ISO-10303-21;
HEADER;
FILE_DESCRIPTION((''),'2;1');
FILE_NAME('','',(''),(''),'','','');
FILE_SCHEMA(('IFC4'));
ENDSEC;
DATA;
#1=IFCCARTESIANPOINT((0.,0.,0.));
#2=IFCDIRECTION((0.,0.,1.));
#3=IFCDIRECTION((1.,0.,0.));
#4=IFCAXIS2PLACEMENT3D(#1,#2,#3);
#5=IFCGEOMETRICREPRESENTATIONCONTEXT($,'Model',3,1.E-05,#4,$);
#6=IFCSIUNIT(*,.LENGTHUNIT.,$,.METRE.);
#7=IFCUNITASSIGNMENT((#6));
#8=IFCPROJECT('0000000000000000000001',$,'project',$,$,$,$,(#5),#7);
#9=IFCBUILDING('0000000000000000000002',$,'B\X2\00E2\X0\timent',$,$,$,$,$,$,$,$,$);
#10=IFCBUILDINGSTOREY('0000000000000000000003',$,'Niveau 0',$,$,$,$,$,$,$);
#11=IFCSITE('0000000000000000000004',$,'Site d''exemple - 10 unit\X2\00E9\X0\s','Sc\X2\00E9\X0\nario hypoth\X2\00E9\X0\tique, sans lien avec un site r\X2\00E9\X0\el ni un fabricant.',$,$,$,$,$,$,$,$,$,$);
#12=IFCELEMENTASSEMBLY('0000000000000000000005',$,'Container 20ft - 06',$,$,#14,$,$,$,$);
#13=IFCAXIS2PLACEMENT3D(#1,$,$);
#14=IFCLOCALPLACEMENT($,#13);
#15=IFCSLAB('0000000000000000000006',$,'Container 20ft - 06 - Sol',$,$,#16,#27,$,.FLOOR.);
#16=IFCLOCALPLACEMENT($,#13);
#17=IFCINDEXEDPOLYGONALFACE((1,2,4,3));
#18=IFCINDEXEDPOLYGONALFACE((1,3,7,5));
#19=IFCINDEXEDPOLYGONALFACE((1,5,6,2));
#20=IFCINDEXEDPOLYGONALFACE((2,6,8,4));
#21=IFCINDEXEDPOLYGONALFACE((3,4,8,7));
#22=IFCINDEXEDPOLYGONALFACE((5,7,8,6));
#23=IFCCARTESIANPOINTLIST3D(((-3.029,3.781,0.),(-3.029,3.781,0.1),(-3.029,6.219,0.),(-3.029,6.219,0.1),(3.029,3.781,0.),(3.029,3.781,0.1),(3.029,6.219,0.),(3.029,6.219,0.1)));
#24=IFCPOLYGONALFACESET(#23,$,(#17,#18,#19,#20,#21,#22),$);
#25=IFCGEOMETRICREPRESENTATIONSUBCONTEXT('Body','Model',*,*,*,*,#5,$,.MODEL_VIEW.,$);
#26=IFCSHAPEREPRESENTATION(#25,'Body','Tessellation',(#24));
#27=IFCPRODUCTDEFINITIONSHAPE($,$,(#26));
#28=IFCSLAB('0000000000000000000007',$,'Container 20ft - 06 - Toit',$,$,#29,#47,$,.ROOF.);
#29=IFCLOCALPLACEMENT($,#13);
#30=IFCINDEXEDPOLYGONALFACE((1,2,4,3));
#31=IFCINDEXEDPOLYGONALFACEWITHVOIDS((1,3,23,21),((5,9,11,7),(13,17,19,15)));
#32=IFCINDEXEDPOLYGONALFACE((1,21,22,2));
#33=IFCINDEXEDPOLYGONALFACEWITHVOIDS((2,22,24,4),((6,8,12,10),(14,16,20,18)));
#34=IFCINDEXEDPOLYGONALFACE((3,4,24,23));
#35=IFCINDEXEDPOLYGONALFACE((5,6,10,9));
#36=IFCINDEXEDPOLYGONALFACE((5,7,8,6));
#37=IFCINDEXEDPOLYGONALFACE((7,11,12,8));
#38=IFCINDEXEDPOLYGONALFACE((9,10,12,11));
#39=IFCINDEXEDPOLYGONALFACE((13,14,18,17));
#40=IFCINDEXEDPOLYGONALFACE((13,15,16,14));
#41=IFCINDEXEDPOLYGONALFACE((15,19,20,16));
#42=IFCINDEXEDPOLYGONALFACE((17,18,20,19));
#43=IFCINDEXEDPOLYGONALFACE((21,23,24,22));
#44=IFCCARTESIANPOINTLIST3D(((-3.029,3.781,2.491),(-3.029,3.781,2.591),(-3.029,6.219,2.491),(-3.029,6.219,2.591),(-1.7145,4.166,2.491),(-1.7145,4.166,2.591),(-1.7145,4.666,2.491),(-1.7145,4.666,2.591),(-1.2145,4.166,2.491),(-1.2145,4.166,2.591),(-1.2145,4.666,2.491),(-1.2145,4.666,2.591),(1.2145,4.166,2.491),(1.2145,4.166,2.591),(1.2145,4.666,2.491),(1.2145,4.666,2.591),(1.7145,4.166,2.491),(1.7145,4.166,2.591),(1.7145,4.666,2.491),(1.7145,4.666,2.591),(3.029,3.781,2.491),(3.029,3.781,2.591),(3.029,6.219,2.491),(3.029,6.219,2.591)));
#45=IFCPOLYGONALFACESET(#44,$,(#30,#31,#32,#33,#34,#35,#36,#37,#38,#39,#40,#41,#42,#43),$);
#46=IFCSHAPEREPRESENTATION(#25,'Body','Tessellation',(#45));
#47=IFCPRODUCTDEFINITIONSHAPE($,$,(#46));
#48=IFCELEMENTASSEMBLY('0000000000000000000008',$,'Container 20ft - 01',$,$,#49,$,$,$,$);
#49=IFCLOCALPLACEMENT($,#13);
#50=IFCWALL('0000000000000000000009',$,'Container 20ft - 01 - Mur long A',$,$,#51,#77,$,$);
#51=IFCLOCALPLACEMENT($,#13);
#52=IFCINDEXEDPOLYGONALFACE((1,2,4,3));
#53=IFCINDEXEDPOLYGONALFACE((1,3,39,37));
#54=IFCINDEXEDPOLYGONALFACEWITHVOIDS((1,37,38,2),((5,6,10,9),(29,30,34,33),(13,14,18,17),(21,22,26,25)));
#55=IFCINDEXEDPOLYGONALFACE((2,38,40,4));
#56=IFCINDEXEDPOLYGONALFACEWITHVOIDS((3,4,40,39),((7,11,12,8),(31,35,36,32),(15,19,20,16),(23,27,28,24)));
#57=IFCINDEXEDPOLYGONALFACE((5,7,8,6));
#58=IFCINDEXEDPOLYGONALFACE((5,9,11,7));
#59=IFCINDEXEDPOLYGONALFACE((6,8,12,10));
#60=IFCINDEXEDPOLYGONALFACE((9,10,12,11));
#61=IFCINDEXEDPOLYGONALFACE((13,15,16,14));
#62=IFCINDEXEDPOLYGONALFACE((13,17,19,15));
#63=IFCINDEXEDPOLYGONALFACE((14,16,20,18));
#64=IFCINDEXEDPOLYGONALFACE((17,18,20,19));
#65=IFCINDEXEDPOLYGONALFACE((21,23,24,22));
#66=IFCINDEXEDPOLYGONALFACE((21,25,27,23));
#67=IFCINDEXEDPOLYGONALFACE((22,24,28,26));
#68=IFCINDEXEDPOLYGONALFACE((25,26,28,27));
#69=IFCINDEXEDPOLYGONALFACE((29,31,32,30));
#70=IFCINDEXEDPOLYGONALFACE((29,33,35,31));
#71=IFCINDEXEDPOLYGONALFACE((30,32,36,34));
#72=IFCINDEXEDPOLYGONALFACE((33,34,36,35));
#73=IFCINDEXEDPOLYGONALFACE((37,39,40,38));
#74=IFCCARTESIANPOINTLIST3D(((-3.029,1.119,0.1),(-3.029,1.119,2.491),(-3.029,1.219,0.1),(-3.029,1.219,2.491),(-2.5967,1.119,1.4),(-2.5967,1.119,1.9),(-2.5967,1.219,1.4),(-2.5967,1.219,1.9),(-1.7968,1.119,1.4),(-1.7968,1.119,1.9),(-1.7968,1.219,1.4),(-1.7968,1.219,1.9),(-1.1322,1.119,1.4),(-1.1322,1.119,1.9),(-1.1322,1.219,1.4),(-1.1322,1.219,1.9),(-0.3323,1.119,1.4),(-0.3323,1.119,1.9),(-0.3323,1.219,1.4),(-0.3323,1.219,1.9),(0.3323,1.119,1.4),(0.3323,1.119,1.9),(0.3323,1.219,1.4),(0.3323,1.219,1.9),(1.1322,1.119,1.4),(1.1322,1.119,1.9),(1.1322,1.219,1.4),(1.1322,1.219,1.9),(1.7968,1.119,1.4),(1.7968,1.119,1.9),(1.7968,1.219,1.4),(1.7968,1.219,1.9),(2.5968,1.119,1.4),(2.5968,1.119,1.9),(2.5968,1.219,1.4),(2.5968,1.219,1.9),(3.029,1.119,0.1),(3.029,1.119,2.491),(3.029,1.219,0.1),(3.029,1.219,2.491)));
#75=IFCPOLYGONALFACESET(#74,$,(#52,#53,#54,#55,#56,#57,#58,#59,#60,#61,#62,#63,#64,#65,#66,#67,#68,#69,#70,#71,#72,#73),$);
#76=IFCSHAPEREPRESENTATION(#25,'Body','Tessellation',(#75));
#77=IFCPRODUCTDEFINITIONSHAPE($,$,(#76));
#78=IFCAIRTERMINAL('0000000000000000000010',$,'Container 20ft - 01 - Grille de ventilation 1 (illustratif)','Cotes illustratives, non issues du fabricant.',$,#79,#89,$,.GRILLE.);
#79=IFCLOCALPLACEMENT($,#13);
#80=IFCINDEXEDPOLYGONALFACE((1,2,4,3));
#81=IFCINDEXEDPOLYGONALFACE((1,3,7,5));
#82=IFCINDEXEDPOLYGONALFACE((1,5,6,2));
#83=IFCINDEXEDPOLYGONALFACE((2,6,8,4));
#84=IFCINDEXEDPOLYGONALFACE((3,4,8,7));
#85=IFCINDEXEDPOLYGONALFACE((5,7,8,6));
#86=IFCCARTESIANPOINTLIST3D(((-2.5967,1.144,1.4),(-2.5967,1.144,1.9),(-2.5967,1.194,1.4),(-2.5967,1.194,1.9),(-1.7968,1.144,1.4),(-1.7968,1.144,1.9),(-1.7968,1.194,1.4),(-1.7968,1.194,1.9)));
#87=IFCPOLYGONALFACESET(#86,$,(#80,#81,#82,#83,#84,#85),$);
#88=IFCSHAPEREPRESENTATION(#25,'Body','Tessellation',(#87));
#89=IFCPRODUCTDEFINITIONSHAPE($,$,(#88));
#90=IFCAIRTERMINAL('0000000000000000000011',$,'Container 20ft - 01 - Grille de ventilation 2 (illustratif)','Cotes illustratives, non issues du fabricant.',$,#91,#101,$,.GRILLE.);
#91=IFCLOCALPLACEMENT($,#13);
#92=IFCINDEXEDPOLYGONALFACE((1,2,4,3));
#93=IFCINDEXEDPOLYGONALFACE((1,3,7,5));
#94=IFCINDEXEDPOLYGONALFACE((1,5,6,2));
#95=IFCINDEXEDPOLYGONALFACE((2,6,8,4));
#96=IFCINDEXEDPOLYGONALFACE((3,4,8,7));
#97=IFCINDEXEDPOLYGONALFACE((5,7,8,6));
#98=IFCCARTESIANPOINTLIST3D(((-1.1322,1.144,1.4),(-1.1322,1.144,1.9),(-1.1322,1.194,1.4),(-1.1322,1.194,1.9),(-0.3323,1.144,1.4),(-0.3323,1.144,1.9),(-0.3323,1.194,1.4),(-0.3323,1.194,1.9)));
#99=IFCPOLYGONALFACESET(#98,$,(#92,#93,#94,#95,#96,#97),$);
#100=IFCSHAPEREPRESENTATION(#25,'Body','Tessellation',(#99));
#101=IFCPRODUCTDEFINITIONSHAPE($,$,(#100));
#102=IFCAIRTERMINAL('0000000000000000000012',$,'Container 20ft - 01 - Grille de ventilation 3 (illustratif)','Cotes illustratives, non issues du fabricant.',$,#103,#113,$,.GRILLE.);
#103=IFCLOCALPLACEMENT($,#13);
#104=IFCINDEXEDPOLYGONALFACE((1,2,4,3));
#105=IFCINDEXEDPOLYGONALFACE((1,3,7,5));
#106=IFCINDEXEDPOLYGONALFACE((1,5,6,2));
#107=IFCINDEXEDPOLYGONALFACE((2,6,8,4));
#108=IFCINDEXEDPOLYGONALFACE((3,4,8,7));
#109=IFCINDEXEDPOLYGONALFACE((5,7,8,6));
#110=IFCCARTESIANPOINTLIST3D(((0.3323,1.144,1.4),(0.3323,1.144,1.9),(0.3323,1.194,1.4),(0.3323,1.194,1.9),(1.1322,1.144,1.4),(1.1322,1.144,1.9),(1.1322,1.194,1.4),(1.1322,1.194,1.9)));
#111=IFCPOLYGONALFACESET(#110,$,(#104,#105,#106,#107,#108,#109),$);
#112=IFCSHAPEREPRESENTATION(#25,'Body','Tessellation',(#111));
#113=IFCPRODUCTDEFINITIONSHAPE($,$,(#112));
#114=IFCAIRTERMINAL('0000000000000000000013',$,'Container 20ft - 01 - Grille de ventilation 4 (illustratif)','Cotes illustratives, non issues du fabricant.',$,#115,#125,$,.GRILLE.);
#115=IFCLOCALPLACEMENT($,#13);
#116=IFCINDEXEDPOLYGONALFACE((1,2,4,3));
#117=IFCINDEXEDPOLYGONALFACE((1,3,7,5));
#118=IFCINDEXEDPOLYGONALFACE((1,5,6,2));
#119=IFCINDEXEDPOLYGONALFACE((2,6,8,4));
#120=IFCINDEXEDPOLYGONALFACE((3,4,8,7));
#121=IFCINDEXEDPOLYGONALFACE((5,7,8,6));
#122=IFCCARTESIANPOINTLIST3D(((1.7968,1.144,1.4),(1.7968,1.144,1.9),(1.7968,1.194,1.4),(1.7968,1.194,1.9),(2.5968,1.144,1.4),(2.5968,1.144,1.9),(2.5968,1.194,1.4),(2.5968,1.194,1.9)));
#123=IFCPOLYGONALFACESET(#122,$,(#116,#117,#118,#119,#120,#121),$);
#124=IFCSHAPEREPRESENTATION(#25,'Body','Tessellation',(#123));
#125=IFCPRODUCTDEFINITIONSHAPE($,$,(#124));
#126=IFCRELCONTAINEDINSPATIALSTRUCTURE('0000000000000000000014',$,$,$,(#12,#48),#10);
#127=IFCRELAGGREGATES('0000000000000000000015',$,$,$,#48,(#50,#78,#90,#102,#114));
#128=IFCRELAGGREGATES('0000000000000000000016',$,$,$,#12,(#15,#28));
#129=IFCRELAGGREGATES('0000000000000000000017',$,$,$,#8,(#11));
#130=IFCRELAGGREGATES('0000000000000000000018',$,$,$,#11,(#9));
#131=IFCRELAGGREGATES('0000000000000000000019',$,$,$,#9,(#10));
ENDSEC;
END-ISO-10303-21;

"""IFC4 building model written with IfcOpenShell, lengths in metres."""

from ifc_helpers import new_model, si_unit, frame, origin_with_axes, place, context, subcontext, project, spatial, rectangle, extrude, element, fill, aggregate, save


model = new_model("IFC4")

# Units and contexts
model_context = context("Model", 3, precision=1e-05, world=origin_with_axes())
body_context = subcontext(model_context, "Body", "Model", "MODEL_VIEW")
ifc_project = project(units=[si_unit("LENGTHUNIT", "METRE")], contexts=[model_context])

# Site, building, storey
site = spatial("IfcSite", under=ifc_project, Name="Site d'exemple - 10 unités", Description="Scénario hypothétique, sans lien avec un site réel ni un fabricant.")
building = spatial("IfcBuilding", under=site, Name="Bâtiment")
storey = spatial("IfcBuildingStorey", under=building, Name="Niveau 0")

# Element assembly, slabs, openings
assembly_1 = element("IfcElementAssembly", 1, inside=storey, Name="Container 20ft - 06")
slab_1_placement = place(None, frame((0.0, 5.0, 0.0), z_axis=(0.0, 0.0, 1.0), x_axis=(1.0, 0.0, 0.0)))
slab_1 = element("IfcSlab", 2, at=slab_1_placement, Name="Container 20ft - 06 - Sol", PredefinedType="FLOOR", context=body_context, shape_type="SweptSolid", body=[
    extrude(rectangle(XDim=6.058, YDim=2.438), origin_with_axes(), (0.0, 0.0, 1.0), 0.1),
])
slab_2_placement = place(None, frame((0.0, 5.0, 2.491), z_axis=(0.0, 0.0, 1.0), x_axis=(1.0, 0.0, 0.0)))
slab_2 = element("IfcSlab", 3, at=slab_2_placement, Name="Container 20ft - 06 - Toit", PredefinedType="ROOF", context=body_context, shape_type="SweptSolid", body=[
    extrude(rectangle(XDim=6.058, YDim=2.438), origin_with_axes(), (0.0, 0.0, 1.0), 0.1),
])
opening_1_placement = place(None, frame((-1.4645, 4.416, 2.441), z_axis=(0.0, 0.0, 1.0), x_axis=(1.0, 0.0, 0.0)))
element("IfcOpeningElement", 4, at=opening_1_placement, cuts=slab_2, PredefinedType="OPENING", context=body_context, shape_type="SweptSolid", body=[
    extrude(rectangle(XDim=0.5, YDim=0.5), origin_with_axes(), (0.0, 0.0, 1.0), 0.2),
])
opening_2_placement = place(None, frame((1.4645, 4.416, 2.441), z_axis=(0.0, 0.0, 1.0), x_axis=(1.0, 0.0, 0.0)))
element("IfcOpeningElement", 5, at=opening_2_placement, cuts=slab_2, PredefinedType="OPENING", context=body_context, shape_type="SweptSolid", body=[
    extrude(rectangle(XDim=0.5, YDim=0.5), origin_with_axes(), (0.0, 0.0, 1.0), 0.2),
])

# Element assembly, wall, openings, air terminals
assembly_2 = element("IfcElementAssembly", 6, inside=storey, Name="Container 20ft - 01")
wall_1_placement = place(None, frame((0.0, 1.169, 0.1), z_axis=(0.0, 0.0, 1.0), x_axis=(1.0, 0.0, 0.0)))
wall_1 = element("IfcWall", 7, at=wall_1_placement, Name="Container 20ft - 01 - Mur long A", context=body_context, shape_type="SweptSolid", body=[
    extrude(rectangle(XDim=6.058, YDim=0.1), origin_with_axes(), (0.0, 0.0, 1.0), 2.391),
])
opening_3_placement = place(None, frame((-2.1967, 1.169, 1.4), z_axis=(0.0, 0.0, 1.0), x_axis=(1.0, 0.0, 0.0)))
opening_3 = element("IfcOpeningElement", 8, at=opening_3_placement, cuts=wall_1, PredefinedType="OPENING", context=body_context, shape_type="SweptSolid", body=[
    extrude(rectangle(XDim=0.8, YDim=0.2), origin_with_axes(), (0.0, 0.0, 1.0), 0.5),
])
opening_4_placement = place(None, frame((-0.7323, 1.169, 1.4), z_axis=(0.0, 0.0, 1.0), x_axis=(1.0, 0.0, 0.0)))
opening_4 = element("IfcOpeningElement", 9, at=opening_4_placement, cuts=wall_1, PredefinedType="OPENING", context=body_context, shape_type="SweptSolid", body=[
    extrude(rectangle(XDim=0.8, YDim=0.2), origin_with_axes(), (0.0, 0.0, 1.0), 0.5),
])
opening_5_placement = place(None, frame((0.7323, 1.169, 1.4), z_axis=(0.0, 0.0, 1.0), x_axis=(1.0, 0.0, 0.0)))
opening_5 = element("IfcOpeningElement", 10, at=opening_5_placement, cuts=wall_1, PredefinedType="OPENING", context=body_context, shape_type="SweptSolid", body=[
    extrude(rectangle(XDim=0.8, YDim=0.2), origin_with_axes(), (0.0, 0.0, 1.0), 0.5),
])
opening_6_placement = place(None, frame((2.1968, 1.169, 1.4), z_axis=(0.0, 0.0, 1.0), x_axis=(1.0, 0.0, 0.0)))
opening_6 = element("IfcOpeningElement", 11, at=opening_6_placement, cuts=wall_1, PredefinedType="OPENING", context=body_context, shape_type="SweptSolid", body=[
    extrude(rectangle(XDim=0.8, YDim=0.2), origin_with_axes(), (0.0, 0.0, 1.0), 0.5),
])
air_terminal_1_placement = place(None, frame((-2.1967, 1.169, 1.4), z_axis=(0.0, 0.0, 1.0), x_axis=(1.0, 0.0, 0.0)))
air_terminal_1 = element("IfcAirTerminal", 12, at=air_terminal_1_placement, Name="Container 20ft - 01 - Grille de ventilation 1 (illustratif)", Description="Cotes illustratives, non issues du fabricant.", PredefinedType="GRILLE", context=body_context, shape_type="SweptSolid", body=[
    extrude(rectangle(XDim=0.8, YDim=0.05), origin_with_axes(), (0.0, 0.0, 1.0), 0.5),
])
fill(opening_3, air_terminal_1)
air_terminal_2_placement = place(None, frame((-0.7323, 1.169, 1.4), z_axis=(0.0, 0.0, 1.0), x_axis=(1.0, 0.0, 0.0)))
air_terminal_2 = element("IfcAirTerminal", 13, at=air_terminal_2_placement, Name="Container 20ft - 01 - Grille de ventilation 2 (illustratif)", Description="Cotes illustratives, non issues du fabricant.", PredefinedType="GRILLE", context=body_context, shape_type="SweptSolid", body=[
    extrude(rectangle(XDim=0.8, YDim=0.05), origin_with_axes(), (0.0, 0.0, 1.0), 0.5),
])
fill(opening_4, air_terminal_2)
air_terminal_3_placement = place(None, frame((0.7323, 1.169, 1.4), z_axis=(0.0, 0.0, 1.0), x_axis=(1.0, 0.0, 0.0)))
air_terminal_3 = element("IfcAirTerminal", 14, at=air_terminal_3_placement, Name="Container 20ft - 01 - Grille de ventilation 3 (illustratif)", Description="Cotes illustratives, non issues du fabricant.", PredefinedType="GRILLE", context=body_context, shape_type="SweptSolid", body=[
    extrude(rectangle(XDim=0.8, YDim=0.05), origin_with_axes(), (0.0, 0.0, 1.0), 0.5),
])
fill(opening_5, air_terminal_3)
air_terminal_4_placement = place(None, frame((2.1968, 1.169, 1.4), z_axis=(0.0, 0.0, 1.0), x_axis=(1.0, 0.0, 0.0)))
air_terminal_4 = element("IfcAirTerminal", 15, at=air_terminal_4_placement, Name="Container 20ft - 01 - Grille de ventilation 4 (illustratif)", Description="Cotes illustratives, non issues du fabricant.", PredefinedType="GRILLE", context=body_context, shape_type="SweptSolid", body=[
    extrude(rectangle(XDim=0.8, YDim=0.05), origin_with_axes(), (0.0, 0.0, 1.0), 0.5),
])
fill(opening_6, air_terminal_4)
aggregate(assembly_2, [wall_1, air_terminal_1, air_terminal_2, air_terminal_3, air_terminal_4])

aggregate(assembly_1, [slab_1, slab_2])

save(model, "model.ifc")
